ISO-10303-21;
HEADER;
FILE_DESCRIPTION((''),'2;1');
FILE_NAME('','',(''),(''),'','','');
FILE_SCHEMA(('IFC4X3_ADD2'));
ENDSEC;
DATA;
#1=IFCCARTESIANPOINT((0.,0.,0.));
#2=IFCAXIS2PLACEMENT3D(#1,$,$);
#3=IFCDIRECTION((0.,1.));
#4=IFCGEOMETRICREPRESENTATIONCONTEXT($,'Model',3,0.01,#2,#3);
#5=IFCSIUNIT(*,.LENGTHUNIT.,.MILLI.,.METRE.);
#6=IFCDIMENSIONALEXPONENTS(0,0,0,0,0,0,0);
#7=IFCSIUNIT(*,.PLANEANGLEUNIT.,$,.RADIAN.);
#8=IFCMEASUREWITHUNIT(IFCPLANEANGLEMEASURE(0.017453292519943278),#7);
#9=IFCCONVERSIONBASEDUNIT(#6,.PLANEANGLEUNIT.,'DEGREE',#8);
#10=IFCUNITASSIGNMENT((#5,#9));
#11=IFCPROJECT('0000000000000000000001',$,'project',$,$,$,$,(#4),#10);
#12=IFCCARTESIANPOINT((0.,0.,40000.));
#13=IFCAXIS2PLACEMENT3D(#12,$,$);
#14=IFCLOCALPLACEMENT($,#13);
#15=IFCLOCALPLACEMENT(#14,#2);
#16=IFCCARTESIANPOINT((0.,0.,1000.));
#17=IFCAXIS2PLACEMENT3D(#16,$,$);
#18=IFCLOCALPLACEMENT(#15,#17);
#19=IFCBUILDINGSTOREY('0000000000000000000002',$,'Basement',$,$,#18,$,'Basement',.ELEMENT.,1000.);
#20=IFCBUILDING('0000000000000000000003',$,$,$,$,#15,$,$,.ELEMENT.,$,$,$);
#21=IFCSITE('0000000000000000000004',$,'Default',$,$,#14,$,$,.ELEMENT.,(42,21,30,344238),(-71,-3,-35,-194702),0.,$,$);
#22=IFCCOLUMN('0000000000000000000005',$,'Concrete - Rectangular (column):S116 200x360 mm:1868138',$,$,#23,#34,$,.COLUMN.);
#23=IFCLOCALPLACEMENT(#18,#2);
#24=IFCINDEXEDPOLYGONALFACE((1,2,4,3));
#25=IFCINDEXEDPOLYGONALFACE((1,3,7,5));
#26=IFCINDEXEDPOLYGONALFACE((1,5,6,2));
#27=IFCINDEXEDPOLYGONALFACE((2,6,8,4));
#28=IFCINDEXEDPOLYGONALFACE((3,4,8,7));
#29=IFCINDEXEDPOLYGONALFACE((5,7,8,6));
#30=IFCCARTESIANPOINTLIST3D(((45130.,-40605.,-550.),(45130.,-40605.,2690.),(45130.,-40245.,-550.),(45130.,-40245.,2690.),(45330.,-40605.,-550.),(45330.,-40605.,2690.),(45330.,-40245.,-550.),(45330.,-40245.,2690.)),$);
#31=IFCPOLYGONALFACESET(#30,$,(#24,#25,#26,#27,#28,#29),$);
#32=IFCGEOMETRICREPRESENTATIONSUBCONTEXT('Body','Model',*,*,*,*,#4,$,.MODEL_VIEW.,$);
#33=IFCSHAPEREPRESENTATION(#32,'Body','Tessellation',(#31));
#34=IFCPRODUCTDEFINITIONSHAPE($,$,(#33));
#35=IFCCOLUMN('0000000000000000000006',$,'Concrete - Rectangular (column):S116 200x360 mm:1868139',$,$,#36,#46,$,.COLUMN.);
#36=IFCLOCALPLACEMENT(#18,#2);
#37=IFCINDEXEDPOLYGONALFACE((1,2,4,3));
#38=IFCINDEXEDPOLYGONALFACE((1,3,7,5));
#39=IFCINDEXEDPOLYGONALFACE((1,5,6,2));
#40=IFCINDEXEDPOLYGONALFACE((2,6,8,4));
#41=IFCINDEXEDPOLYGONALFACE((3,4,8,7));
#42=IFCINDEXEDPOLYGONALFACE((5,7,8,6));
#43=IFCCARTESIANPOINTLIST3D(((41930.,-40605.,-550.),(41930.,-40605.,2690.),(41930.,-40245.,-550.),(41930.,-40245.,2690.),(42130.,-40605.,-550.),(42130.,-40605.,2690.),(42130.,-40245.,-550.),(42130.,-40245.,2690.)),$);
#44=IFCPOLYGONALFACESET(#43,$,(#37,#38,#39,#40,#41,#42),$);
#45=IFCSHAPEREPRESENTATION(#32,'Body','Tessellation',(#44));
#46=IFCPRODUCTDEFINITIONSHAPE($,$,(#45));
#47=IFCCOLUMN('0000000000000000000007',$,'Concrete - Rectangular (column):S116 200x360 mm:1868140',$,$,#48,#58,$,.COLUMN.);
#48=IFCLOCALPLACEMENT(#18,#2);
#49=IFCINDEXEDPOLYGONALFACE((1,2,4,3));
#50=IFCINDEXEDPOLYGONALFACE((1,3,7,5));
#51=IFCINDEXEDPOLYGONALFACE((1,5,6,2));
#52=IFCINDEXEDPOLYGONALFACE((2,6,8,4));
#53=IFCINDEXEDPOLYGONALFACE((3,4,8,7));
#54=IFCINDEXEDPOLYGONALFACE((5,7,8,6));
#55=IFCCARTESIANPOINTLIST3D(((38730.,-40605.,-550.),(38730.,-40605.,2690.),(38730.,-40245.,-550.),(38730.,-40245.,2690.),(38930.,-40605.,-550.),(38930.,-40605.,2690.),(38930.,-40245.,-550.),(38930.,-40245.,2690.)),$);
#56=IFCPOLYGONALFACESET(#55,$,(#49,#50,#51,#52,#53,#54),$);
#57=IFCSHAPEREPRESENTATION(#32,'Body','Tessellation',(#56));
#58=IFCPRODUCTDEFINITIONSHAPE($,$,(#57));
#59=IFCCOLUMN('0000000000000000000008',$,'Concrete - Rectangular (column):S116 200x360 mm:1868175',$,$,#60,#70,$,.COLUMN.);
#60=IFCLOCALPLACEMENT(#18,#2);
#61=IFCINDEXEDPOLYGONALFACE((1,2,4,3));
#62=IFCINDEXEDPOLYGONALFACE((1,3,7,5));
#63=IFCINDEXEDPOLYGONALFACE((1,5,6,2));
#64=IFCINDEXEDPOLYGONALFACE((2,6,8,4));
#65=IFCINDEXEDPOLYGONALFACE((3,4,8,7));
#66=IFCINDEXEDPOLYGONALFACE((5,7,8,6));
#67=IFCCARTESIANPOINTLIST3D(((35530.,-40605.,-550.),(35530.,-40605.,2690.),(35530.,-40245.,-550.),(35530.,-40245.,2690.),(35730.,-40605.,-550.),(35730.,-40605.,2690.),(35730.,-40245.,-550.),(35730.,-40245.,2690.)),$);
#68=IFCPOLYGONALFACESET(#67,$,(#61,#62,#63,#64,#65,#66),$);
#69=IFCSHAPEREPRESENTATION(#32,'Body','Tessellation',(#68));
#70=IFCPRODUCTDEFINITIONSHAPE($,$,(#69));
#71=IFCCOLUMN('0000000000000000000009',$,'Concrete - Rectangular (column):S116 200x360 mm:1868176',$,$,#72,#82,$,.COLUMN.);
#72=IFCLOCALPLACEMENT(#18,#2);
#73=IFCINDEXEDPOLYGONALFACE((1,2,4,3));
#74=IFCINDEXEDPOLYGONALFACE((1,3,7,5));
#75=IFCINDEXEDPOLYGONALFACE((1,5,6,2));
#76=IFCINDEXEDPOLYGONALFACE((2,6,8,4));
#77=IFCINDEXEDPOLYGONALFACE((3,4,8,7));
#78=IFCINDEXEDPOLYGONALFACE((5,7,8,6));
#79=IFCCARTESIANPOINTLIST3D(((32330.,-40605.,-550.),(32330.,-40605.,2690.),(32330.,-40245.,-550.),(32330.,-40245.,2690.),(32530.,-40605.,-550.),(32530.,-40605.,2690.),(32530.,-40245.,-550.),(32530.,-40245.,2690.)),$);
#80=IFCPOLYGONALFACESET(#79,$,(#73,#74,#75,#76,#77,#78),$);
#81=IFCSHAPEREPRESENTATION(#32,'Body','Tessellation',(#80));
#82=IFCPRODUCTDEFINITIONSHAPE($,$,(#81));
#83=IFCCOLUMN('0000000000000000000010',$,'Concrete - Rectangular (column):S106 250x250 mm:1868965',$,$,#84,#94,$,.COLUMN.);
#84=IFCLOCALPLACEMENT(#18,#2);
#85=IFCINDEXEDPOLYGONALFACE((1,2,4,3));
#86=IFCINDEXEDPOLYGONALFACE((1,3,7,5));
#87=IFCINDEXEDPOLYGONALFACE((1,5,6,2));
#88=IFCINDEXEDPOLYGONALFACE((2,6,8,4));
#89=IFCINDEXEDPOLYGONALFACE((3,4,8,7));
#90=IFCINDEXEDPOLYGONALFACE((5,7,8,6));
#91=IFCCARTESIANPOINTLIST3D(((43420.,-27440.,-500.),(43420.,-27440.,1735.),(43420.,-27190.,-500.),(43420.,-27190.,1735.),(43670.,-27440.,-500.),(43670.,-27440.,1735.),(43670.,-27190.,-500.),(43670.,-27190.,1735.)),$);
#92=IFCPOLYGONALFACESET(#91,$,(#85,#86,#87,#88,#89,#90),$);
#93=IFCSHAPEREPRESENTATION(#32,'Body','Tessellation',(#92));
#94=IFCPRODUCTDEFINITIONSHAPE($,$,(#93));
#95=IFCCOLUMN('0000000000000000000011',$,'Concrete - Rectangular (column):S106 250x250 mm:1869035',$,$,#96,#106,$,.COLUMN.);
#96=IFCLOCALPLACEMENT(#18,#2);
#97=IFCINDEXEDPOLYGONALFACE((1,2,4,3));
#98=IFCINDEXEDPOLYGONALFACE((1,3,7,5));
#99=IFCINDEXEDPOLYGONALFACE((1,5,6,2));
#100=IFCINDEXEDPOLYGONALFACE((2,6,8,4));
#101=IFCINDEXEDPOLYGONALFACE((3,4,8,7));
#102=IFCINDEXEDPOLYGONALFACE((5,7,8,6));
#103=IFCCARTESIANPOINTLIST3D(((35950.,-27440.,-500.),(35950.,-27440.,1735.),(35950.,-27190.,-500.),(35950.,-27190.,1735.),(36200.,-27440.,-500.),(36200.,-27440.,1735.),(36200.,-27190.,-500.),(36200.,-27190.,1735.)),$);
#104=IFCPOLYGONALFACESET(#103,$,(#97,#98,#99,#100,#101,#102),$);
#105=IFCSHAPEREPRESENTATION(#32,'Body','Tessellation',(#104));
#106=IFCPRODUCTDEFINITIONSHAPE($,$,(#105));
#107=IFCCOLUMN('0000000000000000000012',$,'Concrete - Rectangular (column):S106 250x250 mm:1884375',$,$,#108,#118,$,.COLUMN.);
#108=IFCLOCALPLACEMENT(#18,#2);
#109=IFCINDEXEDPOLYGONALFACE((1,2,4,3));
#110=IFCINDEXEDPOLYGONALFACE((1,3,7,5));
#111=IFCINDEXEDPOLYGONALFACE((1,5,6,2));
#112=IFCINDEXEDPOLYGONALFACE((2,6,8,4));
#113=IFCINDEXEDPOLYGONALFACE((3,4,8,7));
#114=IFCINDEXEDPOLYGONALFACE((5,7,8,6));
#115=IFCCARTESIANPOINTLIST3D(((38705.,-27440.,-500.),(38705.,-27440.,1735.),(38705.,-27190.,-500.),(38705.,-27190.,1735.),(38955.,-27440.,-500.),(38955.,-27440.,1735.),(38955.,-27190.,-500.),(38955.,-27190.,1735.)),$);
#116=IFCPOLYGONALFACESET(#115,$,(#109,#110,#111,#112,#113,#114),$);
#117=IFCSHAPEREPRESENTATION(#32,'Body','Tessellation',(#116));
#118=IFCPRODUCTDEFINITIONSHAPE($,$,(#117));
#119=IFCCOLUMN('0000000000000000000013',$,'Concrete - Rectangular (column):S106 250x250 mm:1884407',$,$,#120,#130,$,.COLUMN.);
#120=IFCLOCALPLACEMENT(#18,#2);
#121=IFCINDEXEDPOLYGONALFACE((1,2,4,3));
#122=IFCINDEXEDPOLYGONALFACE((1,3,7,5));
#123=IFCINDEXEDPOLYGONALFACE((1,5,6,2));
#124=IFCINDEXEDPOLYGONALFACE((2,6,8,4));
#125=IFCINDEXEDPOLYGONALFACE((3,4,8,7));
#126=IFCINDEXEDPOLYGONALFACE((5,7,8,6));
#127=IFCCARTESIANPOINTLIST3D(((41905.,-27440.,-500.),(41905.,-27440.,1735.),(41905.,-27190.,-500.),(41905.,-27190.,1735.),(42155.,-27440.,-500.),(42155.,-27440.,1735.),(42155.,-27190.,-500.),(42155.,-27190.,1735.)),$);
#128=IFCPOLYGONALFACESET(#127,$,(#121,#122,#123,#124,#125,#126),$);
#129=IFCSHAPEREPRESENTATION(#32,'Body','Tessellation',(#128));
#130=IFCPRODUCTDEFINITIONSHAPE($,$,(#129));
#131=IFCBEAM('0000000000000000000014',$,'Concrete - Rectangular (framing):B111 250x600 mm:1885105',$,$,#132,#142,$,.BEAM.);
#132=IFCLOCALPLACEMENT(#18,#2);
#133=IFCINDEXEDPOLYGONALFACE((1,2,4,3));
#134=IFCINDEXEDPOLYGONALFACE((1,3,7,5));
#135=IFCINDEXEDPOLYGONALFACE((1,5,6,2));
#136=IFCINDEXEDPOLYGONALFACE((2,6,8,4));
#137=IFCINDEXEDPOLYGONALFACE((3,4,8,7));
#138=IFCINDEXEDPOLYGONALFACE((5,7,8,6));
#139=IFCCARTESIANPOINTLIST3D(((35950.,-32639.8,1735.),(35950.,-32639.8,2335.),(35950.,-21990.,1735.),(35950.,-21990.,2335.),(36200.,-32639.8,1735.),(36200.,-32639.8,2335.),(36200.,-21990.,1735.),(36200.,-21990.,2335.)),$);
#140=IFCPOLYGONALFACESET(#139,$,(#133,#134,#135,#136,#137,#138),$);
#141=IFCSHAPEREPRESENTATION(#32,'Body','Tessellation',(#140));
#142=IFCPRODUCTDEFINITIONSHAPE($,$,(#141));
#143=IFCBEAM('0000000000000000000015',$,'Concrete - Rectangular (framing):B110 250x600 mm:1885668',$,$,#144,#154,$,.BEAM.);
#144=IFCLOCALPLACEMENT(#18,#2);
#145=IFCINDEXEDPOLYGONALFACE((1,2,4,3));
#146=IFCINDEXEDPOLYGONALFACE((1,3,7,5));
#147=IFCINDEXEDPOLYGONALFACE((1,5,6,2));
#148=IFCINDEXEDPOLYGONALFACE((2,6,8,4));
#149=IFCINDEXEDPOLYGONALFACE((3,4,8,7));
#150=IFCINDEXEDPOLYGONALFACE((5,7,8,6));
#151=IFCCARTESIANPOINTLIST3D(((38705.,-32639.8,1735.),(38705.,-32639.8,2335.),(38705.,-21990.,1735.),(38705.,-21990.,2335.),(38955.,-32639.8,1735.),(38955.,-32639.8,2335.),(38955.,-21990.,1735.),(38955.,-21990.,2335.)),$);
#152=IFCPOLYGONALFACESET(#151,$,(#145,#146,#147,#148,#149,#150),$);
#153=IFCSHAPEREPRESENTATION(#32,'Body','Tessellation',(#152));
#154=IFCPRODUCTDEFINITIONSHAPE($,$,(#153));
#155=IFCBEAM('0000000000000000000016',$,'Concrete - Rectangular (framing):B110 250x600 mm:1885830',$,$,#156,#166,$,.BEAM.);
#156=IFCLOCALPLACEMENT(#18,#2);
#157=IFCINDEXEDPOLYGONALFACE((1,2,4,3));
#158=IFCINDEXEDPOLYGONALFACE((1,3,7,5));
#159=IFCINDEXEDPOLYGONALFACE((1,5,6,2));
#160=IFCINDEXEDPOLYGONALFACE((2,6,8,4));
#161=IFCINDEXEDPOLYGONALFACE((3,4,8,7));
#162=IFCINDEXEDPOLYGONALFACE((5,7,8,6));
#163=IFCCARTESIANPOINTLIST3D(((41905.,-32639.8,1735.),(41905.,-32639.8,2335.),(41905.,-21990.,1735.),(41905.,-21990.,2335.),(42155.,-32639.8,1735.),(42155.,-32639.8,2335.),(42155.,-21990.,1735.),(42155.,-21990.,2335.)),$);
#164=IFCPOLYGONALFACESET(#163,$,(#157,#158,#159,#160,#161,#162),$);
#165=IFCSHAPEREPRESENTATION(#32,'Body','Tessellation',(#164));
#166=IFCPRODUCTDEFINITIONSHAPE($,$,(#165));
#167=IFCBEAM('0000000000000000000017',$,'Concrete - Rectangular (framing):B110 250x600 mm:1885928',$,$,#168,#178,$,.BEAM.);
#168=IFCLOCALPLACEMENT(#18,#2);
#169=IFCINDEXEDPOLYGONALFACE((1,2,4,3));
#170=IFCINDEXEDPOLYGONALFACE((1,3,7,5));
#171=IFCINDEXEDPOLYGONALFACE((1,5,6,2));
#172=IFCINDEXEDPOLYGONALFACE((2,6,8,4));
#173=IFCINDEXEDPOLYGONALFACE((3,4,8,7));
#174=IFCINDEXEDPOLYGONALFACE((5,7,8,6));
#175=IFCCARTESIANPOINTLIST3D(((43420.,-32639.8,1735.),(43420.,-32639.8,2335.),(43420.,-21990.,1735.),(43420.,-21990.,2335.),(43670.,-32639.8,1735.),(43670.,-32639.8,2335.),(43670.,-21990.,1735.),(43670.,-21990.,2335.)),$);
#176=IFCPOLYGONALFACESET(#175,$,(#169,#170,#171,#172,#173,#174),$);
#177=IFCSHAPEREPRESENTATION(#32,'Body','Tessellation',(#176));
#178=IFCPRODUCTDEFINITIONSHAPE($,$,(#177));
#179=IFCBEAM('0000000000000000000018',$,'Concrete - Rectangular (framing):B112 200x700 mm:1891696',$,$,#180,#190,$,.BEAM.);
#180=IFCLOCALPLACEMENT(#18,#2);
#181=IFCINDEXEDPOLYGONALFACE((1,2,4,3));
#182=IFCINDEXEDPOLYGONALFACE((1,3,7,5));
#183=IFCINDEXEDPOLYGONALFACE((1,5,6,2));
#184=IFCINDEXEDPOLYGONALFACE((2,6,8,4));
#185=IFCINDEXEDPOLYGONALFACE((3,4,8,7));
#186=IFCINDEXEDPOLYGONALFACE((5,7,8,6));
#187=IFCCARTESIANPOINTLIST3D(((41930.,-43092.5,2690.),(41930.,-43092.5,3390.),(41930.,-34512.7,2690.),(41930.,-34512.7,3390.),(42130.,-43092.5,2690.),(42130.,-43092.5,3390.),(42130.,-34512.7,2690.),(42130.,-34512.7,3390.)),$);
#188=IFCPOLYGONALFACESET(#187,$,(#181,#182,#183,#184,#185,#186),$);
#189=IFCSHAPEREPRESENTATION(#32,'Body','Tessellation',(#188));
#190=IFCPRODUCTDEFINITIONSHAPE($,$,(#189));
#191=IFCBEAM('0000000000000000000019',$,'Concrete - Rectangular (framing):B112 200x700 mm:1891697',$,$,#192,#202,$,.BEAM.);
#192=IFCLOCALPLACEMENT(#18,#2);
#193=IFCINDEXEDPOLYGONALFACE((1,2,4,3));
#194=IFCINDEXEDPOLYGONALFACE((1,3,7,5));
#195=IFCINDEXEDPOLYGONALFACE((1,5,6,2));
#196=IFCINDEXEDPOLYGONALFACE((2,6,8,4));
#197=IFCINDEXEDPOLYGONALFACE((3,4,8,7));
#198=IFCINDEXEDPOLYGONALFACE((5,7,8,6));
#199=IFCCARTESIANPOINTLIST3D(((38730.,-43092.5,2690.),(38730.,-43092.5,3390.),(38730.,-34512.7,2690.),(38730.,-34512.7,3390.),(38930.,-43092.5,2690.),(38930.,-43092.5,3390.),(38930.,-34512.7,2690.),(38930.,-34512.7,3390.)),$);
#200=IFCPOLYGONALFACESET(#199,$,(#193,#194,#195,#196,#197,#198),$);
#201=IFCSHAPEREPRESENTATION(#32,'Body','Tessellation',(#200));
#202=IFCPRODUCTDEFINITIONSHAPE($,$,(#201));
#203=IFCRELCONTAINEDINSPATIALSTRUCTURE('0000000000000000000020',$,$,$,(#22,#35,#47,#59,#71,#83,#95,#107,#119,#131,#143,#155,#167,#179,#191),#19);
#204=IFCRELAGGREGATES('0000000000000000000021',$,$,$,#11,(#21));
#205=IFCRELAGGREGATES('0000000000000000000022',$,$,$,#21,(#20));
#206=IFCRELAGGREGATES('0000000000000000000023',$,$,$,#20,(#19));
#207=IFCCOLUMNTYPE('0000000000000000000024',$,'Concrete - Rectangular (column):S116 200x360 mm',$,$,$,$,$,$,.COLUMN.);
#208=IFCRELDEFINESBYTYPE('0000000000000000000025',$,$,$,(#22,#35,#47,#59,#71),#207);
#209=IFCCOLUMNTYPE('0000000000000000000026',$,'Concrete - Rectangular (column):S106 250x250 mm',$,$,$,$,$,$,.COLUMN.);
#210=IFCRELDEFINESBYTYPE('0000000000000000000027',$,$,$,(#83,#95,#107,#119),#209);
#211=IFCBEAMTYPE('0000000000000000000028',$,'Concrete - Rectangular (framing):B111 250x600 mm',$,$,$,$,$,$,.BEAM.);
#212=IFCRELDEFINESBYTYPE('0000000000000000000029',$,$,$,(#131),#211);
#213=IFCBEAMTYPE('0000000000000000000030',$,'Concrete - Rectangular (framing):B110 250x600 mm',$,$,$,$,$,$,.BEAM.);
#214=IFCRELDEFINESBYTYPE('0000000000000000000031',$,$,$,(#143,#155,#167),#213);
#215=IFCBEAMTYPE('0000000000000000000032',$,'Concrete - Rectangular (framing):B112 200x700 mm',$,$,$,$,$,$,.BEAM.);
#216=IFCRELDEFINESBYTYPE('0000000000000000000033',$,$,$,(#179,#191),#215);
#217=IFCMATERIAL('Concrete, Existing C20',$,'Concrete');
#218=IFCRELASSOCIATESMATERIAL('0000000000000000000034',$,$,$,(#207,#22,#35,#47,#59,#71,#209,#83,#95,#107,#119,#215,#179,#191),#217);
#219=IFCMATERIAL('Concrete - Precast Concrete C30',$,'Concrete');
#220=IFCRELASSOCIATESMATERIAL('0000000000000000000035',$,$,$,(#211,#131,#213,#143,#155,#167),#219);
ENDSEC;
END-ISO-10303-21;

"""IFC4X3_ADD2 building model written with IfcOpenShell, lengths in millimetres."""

from ifc_helpers import new_model, entity, si_unit, converted_unit, direction, frame, frame_2d, origin, origin_2d_with_axis, place, context, subcontext, project, spatial, rectangle, extrude, source, transform, mapped, material, material_profile, profile_set, profile_usage, type_object, type_shapes, element, save


model = new_model("IFC4X3_ADD2")

# Units and contexts
model_context = context("Model", 3, precision=0.01, world=origin(), true_north=direction((0.0, 1.0)))
body_context = subcontext(model_context, "Body", "Model", "MODEL_VIEW")
ifc_project = project(units=[si_unit("LENGTHUNIT", "METRE", prefix="MILLI"), converted_unit("PLANEANGLEUNIT", "DEGREE", entity("IfcPlaneAngleMeasure", 0.017453292519943278), si_unit("PLANEANGLEUNIT", "RADIAN"), dimensions=[0, 0, 0, 0, 0, 0, 0])], contexts=[model_context])

# Site, building, storey
site_placement = place(None, frame((0.0, 0.0, 40000.0)))
site = spatial("IfcSite", under=ifc_project, at=site_placement, Name="Default", CompositionType="ELEMENT", RefLatitude=(42, 21, 30, 344238), RefLongitude=(-71, -3, -35, -194702), RefElevation=0.0)
building_placement = place(site_placement, origin())
building = spatial("IfcBuilding", under=site, at=building_placement, CompositionType="ELEMENT")
storey_placement = place(building_placement, frame((0.0, 0.0, 1000.0)))
storey = spatial("IfcBuildingStorey", under=building, at=storey_placement, Name="Basement", LongName="Basement", CompositionType="ELEMENT", Elevation=1000.0)

# Columns
ifc_material_1 = material(Name="Concrete, Existing C20", Category="Concrete")
ifc_material_profile_1 = material_profile(ifc_material_1, rectangle(XDim=360.0, YDim=200.0, at=origin_2d_with_axis()), Name="S116 200x360 mm")
ifc_profile_set_1 = profile_set([ifc_material_profile_1], Name="S116 200x360 mm")
ifc_profile_usage_1 = profile_usage(ifc_profile_set_1)
column_type_1 = type_object("IfcColumnType", Name="Concrete - Rectangular (column):S116 200x360 mm", PredefinedType="COLUMN", material=ifc_profile_set_1)
shared_shape_1 = source(origin(), body_context, "Body", "SweptSolid", [
    extrude(rectangle(XDim=360.0, YDim=200.0, at=origin_2d_with_axis()), frame((0.0, 0.0, 450.0), z_axis=(0.0, 0.0, 1.0), x_axis=(-1.0, 0.0, 0.0)), (0.0, 0.0, 1.0), 3240.0),
])
type_shapes(column_type_1, [shared_shape_1])
for number, where, z_axis, x_axis, name in (
    (1, (45230.0, -40425.0, -1000.0), (0.0, 0.0, 1.0), (0.0, -1.0, 0.0), "Concrete - Rectangular (column):S116 200x360 mm:1868138"),
    (2, (42030.0, -40425.0, -1000.0), (0.0, 0.0, 1.0), (0.0, -1.0, 0.0), "Concrete - Rectangular (column):S116 200x360 mm:1868139"),
    (3, (38830.0, -40425.0, -1000.0), (0.0, 0.0, 1.0), (0.0, -1.0, 0.0), "Concrete - Rectangular (column):S116 200x360 mm:1868140"),
    (4, (35630.0, -40425.0, -1000.0), (0.0, 0.0, 1.0), (0.0, -1.0, 0.0), "Concrete - Rectangular (column):S116 200x360 mm:1868175"),
    (5, (32430.0, -40425.0, -1000.0), (0.0, 0.0, 1.0), (0.0, -1.0, 0.0), "Concrete - Rectangular (column):S116 200x360 mm:1868176"),
):
    element("IfcColumn", number, at=place(storey_placement, frame(where, z_axis=z_axis, x_axis=x_axis)), inside=storey, type_object=column_type_1, material=ifc_profile_usage_1, Name=name, PredefinedType="COLUMN", context=body_context, shape_type="MappedRepresentation", body=[
        mapped(shared_shape_1, transform((0.0, 0.0, 0.0), scale=1.0)),
    ])
ifc_material_profile_2 = material_profile(ifc_material_1, rectangle(XDim=250.0, YDim=250.0, at=frame_2d((0.0, 0.0), x_axis=(1.0, 0.0))), Name="S106 250x250 mm")
ifc_profile_set_2 = profile_set([ifc_material_profile_2], Name="S106 250x250 mm")
ifc_profile_usage_2 = profile_usage(ifc_profile_set_2)
column_type_2 = type_object("IfcColumnType", Name="Concrete - Rectangular (column):S106 250x250 mm", PredefinedType="COLUMN", material=ifc_profile_set_2)
shared_shape_2 = source(origin(), body_context, "Body", "SweptSolid", [
    extrude(rectangle(XDim=250.0, YDim=250.0, at=origin_2d_with_axis()), frame((0.0, 0.0, 500.0), z_axis=(0.0, 0.0, 1.0), x_axis=(-1.0, 0.0, 0.0)), (0.0, 0.0, 1.0), 2235.0),
])
type_shapes(column_type_2, [shared_shape_2])
for number, where, z_axis, x_axis, name in (
    (6, (43545.0, -27315.0, -1000.0), (0.0, 0.0, 1.0), (0.0, -1.0, 0.0), "Concrete - Rectangular (column):S106 250x250 mm:1868965"),
    (7, (36075.0, -27315.0, -1000.0), (0.0, 0.0, 1.0), (0.0, -1.0, 0.0), "Concrete - Rectangular (column):S106 250x250 mm:1869035"),
    (8, (38830.0, -27315.0, -1000.0), (0.0, 0.0, 1.0), (0.0, -1.0, 0.0), "Concrete - Rectangular (column):S106 250x250 mm:1884375"),
    (9, (42030.0, -27315.0, -1000.0), (0.0, 0.0, 1.0), (0.0, -1.0, 0.0), "Concrete - Rectangular (column):S106 250x250 mm:1884407"),
):
    element("IfcColumn", number, at=place(storey_placement, frame(where, z_axis=z_axis, x_axis=x_axis)), inside=storey, type_object=column_type_2, material=ifc_profile_usage_2, Name=name, PredefinedType="COLUMN", context=body_context, shape_type="MappedRepresentation", body=[
        mapped(shared_shape_2, transform((0.0, 0.0, 0.0), scale=1.0)),
    ])

# Beams
ifc_material_2 = material(Name="Concrete - Precast Concrete C30", Category="Concrete")
ifc_material_profile_3 = material_profile(ifc_material_2, rectangle(XDim=10649.8, YDim=250.0, at=origin_2d_with_axis()), Name="B111 250x600 mm")
ifc_profile_set_3 = profile_set([ifc_material_profile_3], Name="B111 250x600 mm")
ifc_profile_usage_3 = profile_usage(ifc_profile_set_3, cardinal=8)
beam_type_1 = type_object("IfcBeamType", Name="Concrete - Rectangular (framing):B111 250x600 mm", PredefinedType="BEAM", material=ifc_profile_set_3)
shared_shape_3 = source(origin(), body_context, "Body", "SweptSolid", [
    extrude(rectangle(XDim=10649.8, YDim=250.0, at=origin_2d_with_axis()), frame((-10.1, 0.0, -300.0), z_axis=(0.0, 0.0, 1.0), x_axis=(-1.0, 0.0, 0.0)), (0.0, 0.0, 1.0), 600.0),
])
type_shapes(beam_type_1, [shared_shape_3])
beam_1_placement = place(storey_placement, frame((36075.0, -27325.0, 2035.0), z_axis=(0.0, 0.0, 1.0), x_axis=(0.0, -1.0, 0.0)))
element("IfcBeam", 10, at=beam_1_placement, inside=storey, type_object=beam_type_1, material=ifc_profile_usage_3, Name="Concrete - Rectangular (framing):B111 250x600 mm:1885105", PredefinedType="BEAM", context=body_context, shape_type="MappedRepresentation", body=[
    mapped(shared_shape_3, transform((0.0, 0.0, 0.0), scale=1.0)),
])
ifc_material_profile_4 = material_profile(ifc_material_2, rectangle(XDim=10649.8, YDim=250.0, at=origin_2d_with_axis()), Name="B110 250x600 mm")
ifc_profile_set_4 = profile_set([ifc_material_profile_4], Name="B110 250x600 mm")
ifc_profile_usage_4 = profile_usage(ifc_profile_set_4, cardinal=8)
beam_type_2 = type_object("IfcBeamType", Name="Concrete - Rectangular (framing):B110 250x600 mm", PredefinedType="BEAM", material=ifc_profile_set_4)
shared_shape_4 = source(origin(), body_context, "Body", "SweptSolid", [
    extrude(rectangle(XDim=10649.8, YDim=250.0, at=origin_2d_with_axis()), frame((-10.1, 0.0, -300.0), z_axis=(0.0, 0.0, 1.0), x_axis=(-1.0, 0.0, 0.0)), (0.0, 0.0, 1.0), 600.0),
])
type_shapes(beam_type_2, [shared_shape_4])
for number, where, z_axis, x_axis, name in (
    (11, (38830.0, -27325.0, 2035.0), (0.0, 0.0, 1.0), (0.0, -1.0, 0.0), "Concrete - Rectangular (framing):B110 250x600 mm:1885668"),
    (12, (42030.0, -27325.0, 2035.0), (0.0, 0.0, 1.0), (0.0, -1.0, 0.0), "Concrete - Rectangular (framing):B110 250x600 mm:1885830"),
    (13, (43545.0, -27325.0, 2035.0), (0.0, 0.0, 1.0), (0.0, -1.0, 0.0), "Concrete - Rectangular (framing):B110 250x600 mm:1885928"),
):
    element("IfcBeam", number, at=place(storey_placement, frame(where, z_axis=z_axis, x_axis=x_axis)), inside=storey, type_object=beam_type_2, material=ifc_profile_usage_4, Name=name, PredefinedType="BEAM", context=body_context, shape_type="MappedRepresentation", body=[
        mapped(shared_shape_4, transform((0.0, 0.0, 0.0), scale=1.0)),
    ])
ifc_material_profile_5 = material_profile(ifc_material_1, rectangle(XDim=8579.8, YDim=200.0, at=origin_2d_with_axis()), Name="B112 200x700 mm")
ifc_profile_set_5 = profile_set([ifc_material_profile_5], Name="B112 200x700 mm")
ifc_profile_usage_5 = profile_usage(ifc_profile_set_5, cardinal=8)
beam_type_3 = type_object("IfcBeamType", Name="Concrete - Rectangular (framing):B112 200x700 mm", PredefinedType="BEAM", material=ifc_profile_set_5)
shared_shape_5 = source(origin(), body_context, "Body", "SweptSolid", [
    extrude(rectangle(XDim=8579.8, YDim=200.0, at=origin_2d_with_axis()), frame((72.6, 0.0, -350.0), z_axis=(0.0, 0.0, 1.0), x_axis=(-1.0, 0.0, 0.0)), (0.0, 0.0, 1.0), 700.0),
])
type_shapes(beam_type_3, [shared_shape_5])
for number, where, z_axis, x_axis, name in (
    (14, (42030.0, -38730.0, 3040.0), (0.0, 0.0, 1.0), (0.0, -1.0, 0.0), "Concrete - Rectangular (framing):B112 200x700 mm:1891696"),
    (15, (38830.0, -38730.0, 3040.0), (0.0, 0.0, 1.0), (0.0, -1.0, 0.0), "Concrete - Rectangular (framing):B112 200x700 mm:1891697"),
):
    element("IfcBeam", number, at=place(storey_placement, frame(where, z_axis=z_axis, x_axis=x_axis)), inside=storey, type_object=beam_type_3, material=ifc_profile_usage_5, Name=name, PredefinedType="BEAM", context=body_context, shape_type="MappedRepresentation", body=[
        mapped(shared_shape_5, transform((0.0, 0.0, 0.0), scale=1.0)),
    ])

save(model, "model.ifc")
